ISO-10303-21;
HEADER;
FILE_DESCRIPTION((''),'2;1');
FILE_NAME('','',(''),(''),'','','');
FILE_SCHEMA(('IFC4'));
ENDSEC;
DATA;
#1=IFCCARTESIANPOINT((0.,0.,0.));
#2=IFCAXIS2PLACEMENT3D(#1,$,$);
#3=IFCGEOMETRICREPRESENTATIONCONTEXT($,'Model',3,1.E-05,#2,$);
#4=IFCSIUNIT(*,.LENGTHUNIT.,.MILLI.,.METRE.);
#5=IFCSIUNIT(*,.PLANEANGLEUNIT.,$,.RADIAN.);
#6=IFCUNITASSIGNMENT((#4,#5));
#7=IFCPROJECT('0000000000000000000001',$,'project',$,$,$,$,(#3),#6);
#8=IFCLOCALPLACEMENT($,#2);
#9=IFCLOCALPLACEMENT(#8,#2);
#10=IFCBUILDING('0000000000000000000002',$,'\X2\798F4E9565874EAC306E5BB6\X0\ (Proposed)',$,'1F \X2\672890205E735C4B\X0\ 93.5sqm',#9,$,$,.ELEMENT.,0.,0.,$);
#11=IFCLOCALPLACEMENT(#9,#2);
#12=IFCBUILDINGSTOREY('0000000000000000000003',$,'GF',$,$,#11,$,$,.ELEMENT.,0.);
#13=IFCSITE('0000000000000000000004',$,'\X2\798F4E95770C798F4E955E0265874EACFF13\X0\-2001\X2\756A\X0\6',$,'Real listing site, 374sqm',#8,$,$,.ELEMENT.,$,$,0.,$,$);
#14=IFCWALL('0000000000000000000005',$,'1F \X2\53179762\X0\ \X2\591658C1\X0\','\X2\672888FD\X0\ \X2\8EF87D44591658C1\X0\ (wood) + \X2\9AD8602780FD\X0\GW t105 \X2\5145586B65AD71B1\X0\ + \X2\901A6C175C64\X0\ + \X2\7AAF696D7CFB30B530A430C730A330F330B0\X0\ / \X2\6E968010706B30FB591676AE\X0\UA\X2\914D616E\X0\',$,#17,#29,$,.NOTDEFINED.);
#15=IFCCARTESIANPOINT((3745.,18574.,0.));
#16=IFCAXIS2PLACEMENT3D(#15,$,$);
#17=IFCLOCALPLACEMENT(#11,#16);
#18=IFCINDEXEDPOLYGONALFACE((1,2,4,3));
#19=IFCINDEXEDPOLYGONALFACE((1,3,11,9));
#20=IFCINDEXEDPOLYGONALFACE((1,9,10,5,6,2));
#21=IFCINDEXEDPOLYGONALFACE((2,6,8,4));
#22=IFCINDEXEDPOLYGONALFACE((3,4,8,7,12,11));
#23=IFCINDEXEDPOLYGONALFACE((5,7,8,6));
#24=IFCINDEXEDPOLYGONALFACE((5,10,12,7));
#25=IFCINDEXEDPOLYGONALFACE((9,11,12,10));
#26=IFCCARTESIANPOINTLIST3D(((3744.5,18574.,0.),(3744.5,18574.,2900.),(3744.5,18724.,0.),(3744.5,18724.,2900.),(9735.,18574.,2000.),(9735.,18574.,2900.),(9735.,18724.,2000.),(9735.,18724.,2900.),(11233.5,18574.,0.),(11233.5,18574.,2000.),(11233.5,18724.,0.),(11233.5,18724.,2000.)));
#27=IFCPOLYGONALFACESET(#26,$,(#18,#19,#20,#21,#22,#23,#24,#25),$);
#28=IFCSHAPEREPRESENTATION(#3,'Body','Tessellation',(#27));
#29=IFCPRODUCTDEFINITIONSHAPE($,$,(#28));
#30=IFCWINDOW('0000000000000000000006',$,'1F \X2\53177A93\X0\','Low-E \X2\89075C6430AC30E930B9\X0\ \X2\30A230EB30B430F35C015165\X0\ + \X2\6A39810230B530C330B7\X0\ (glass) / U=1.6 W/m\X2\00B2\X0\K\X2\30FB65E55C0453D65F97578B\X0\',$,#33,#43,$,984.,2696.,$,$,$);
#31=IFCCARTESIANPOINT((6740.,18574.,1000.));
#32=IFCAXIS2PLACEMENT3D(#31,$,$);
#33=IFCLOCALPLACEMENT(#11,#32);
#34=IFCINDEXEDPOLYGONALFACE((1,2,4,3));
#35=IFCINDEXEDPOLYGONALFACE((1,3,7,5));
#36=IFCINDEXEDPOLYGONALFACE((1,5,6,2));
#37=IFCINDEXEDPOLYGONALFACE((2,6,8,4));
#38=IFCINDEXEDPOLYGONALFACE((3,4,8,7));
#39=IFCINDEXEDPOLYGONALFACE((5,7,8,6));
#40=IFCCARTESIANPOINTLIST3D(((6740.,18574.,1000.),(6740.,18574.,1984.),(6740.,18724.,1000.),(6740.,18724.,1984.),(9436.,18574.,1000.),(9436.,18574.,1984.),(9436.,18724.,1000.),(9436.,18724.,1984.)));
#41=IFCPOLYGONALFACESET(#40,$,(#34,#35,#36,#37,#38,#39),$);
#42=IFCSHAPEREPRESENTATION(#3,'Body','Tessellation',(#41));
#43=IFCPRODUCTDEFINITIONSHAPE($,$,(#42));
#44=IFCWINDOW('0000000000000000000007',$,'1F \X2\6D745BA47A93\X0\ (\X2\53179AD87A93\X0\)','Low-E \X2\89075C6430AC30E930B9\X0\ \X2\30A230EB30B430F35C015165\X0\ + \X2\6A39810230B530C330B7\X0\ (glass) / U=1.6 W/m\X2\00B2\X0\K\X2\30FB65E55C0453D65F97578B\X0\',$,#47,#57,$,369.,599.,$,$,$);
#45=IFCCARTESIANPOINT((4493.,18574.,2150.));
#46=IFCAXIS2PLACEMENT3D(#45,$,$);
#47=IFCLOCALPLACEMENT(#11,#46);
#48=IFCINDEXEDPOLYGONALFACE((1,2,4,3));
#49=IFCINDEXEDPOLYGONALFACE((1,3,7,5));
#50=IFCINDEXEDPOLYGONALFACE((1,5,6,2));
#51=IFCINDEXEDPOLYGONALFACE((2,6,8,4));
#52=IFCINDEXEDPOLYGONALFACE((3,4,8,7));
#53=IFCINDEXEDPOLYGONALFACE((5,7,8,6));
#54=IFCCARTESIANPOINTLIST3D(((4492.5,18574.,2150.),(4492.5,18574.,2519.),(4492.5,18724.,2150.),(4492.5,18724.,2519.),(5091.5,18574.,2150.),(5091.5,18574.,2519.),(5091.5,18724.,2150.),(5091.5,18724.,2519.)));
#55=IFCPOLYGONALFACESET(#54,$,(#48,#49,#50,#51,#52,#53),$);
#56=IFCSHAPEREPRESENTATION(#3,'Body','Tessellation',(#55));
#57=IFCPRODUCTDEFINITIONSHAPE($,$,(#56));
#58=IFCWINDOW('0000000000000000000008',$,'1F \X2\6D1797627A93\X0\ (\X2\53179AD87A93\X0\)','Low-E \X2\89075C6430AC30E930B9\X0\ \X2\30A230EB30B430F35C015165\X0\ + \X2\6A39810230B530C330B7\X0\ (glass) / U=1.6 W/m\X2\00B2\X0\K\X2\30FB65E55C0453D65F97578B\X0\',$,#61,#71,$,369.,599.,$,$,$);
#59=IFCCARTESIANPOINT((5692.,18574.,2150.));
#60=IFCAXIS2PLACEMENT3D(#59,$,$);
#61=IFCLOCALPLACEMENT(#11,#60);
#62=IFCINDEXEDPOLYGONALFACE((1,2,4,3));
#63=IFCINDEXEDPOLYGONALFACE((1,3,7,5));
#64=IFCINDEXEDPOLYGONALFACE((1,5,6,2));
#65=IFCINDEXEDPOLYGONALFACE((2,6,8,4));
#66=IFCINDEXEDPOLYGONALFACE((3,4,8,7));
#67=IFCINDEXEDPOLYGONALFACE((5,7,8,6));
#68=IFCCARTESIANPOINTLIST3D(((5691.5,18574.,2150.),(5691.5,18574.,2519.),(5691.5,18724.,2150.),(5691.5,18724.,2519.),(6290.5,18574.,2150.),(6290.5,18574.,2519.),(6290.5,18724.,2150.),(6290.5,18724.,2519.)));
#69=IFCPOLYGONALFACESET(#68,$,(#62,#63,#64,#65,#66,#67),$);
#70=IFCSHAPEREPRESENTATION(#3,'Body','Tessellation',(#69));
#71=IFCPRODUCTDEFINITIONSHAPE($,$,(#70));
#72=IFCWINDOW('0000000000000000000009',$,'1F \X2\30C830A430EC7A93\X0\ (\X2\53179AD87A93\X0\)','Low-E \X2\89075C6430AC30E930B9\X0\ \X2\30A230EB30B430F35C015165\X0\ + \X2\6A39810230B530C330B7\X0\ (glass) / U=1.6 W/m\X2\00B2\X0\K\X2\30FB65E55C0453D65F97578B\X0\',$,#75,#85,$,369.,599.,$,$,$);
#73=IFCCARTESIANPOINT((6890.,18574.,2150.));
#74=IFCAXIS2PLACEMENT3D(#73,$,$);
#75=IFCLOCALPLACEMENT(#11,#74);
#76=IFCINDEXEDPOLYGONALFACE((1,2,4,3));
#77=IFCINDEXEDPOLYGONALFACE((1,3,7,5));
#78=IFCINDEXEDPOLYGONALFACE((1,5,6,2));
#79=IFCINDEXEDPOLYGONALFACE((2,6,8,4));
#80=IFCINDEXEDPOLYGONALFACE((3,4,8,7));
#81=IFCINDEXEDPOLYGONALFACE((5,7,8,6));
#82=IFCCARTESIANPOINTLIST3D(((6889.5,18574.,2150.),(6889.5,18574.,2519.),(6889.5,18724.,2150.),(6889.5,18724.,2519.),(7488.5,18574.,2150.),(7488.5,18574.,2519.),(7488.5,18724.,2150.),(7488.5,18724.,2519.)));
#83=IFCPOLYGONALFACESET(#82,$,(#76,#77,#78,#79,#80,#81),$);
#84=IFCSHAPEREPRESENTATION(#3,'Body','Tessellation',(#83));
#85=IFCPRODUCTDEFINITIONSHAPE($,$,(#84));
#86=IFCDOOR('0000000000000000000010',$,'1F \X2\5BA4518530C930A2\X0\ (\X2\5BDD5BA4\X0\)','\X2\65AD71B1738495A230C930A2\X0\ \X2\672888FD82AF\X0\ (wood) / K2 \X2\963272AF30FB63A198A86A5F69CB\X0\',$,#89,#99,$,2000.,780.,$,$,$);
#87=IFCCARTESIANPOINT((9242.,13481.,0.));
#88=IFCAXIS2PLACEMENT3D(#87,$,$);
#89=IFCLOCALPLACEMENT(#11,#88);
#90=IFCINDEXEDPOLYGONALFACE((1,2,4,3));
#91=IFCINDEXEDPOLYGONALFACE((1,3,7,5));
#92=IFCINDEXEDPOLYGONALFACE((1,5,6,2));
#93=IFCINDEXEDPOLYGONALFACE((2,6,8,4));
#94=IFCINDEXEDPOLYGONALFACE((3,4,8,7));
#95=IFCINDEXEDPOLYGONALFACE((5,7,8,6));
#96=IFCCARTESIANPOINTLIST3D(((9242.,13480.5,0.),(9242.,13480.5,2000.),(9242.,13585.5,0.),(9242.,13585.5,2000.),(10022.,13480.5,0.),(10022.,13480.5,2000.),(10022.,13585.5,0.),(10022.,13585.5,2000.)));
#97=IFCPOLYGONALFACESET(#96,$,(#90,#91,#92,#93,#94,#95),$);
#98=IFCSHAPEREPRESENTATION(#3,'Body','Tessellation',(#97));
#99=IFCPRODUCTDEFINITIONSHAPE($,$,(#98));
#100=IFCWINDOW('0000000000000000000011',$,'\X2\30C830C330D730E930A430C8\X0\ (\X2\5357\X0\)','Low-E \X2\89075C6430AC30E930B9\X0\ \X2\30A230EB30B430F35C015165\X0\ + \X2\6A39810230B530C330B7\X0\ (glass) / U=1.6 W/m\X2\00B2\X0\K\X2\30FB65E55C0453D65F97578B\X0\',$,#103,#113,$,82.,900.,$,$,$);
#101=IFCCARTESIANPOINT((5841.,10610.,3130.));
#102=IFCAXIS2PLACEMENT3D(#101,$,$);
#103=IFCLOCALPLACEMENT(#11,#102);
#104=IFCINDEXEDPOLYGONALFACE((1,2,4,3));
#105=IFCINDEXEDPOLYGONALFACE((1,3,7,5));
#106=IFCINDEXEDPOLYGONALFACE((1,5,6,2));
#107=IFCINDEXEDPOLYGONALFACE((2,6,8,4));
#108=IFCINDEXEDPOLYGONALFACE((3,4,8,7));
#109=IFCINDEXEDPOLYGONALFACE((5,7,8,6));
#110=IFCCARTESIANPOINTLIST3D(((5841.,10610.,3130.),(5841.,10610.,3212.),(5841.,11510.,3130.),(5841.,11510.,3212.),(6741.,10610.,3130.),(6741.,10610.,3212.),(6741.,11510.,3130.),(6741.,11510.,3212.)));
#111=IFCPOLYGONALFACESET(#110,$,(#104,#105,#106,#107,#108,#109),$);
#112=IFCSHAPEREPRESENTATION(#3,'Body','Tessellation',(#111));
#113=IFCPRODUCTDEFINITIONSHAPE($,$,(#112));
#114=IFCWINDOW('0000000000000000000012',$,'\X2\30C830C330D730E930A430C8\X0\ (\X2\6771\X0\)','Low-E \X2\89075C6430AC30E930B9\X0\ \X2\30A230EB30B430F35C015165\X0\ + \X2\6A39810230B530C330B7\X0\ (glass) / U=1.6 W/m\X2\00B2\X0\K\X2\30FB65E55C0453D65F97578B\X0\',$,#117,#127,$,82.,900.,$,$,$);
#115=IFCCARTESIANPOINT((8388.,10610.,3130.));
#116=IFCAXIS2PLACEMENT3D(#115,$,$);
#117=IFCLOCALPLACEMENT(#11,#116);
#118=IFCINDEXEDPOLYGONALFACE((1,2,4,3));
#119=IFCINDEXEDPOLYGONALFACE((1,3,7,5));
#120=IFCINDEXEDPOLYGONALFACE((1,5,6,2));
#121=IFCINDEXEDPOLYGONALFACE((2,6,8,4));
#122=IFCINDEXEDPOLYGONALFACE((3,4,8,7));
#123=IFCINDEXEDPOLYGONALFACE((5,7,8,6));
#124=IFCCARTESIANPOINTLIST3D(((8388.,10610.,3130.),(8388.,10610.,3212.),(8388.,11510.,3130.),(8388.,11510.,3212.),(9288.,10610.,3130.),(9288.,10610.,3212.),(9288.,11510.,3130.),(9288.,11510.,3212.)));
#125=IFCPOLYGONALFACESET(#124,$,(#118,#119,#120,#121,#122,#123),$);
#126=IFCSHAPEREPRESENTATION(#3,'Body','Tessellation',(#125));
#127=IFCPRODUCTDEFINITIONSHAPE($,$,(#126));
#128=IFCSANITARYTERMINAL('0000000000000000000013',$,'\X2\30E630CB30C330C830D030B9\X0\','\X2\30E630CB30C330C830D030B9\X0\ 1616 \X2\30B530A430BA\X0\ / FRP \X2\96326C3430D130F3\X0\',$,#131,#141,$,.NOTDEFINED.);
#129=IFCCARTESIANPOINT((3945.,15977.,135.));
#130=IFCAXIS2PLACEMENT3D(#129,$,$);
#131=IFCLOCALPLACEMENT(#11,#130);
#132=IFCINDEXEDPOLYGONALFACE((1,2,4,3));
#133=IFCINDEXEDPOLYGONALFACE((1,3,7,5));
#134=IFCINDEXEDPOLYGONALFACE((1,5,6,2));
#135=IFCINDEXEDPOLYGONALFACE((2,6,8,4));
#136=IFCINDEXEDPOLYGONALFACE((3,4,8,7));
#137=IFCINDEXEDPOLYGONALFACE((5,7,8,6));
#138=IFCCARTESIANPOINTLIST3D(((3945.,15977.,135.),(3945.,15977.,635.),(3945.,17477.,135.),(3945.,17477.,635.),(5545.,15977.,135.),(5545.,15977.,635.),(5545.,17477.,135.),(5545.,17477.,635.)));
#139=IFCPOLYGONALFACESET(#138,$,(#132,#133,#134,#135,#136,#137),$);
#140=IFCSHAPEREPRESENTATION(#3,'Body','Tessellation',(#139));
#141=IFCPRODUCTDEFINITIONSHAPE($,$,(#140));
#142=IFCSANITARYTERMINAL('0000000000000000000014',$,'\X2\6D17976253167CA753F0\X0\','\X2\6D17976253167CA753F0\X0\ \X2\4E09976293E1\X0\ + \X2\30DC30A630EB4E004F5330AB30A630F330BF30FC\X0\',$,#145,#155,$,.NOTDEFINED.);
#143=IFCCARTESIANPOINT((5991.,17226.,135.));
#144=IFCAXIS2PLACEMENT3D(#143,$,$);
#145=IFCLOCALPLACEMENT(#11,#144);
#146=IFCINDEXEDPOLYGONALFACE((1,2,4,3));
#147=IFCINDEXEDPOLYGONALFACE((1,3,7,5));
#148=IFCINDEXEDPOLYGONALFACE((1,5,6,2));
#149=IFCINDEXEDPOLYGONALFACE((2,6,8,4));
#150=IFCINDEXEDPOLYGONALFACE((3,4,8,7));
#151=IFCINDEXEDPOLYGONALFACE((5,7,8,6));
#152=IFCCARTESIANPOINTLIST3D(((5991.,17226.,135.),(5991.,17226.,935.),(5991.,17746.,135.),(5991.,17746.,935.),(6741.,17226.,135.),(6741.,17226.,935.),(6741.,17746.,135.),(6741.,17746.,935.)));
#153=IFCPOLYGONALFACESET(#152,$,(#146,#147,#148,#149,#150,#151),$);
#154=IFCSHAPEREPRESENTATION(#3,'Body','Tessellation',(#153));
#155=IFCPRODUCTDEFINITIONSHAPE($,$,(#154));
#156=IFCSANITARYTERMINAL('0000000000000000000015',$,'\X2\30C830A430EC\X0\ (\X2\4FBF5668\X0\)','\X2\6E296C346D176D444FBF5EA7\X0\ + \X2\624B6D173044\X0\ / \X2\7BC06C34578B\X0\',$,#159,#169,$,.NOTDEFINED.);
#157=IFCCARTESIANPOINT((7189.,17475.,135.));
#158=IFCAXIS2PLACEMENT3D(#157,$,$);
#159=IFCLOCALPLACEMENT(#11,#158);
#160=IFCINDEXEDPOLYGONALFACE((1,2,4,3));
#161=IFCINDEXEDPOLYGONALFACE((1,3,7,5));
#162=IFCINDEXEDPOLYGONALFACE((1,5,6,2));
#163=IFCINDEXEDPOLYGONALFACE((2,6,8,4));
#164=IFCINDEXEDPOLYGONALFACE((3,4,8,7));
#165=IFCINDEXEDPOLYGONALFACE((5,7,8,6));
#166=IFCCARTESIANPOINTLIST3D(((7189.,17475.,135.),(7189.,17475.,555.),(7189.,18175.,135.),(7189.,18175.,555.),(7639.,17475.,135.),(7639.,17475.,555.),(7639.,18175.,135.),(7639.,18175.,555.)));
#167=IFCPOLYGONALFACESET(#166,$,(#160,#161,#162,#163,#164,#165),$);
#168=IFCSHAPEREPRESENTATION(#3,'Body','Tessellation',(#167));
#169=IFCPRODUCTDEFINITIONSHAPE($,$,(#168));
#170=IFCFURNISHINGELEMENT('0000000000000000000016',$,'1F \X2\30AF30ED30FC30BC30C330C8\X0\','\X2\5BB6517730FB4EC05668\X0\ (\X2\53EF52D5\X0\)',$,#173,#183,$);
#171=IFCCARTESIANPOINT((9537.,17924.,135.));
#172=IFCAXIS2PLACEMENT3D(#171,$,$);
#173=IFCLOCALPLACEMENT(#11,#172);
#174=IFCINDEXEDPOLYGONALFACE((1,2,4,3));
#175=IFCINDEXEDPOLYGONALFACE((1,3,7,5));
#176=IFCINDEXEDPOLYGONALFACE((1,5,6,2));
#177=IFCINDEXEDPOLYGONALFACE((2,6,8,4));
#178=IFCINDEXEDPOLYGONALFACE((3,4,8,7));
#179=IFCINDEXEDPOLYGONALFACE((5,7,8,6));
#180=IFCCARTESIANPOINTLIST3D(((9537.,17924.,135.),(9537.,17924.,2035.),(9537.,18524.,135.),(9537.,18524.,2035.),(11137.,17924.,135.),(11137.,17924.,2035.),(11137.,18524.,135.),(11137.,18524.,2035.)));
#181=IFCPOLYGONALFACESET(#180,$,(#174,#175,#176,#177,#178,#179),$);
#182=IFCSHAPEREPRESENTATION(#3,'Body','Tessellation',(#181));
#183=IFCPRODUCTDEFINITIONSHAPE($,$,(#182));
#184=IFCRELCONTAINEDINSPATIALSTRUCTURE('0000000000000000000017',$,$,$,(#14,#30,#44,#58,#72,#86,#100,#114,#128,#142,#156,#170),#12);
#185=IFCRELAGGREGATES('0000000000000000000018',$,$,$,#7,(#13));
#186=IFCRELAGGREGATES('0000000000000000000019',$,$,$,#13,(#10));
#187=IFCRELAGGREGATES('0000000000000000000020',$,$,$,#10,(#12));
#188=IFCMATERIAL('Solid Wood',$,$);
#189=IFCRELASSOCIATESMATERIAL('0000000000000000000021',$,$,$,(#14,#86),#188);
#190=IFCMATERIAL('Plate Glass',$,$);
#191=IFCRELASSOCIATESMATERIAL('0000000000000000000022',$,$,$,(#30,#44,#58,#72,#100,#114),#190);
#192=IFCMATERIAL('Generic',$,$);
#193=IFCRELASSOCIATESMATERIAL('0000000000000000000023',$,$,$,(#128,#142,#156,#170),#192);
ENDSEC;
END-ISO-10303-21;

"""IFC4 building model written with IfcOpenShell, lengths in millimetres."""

from ifc_helpers import new_model, si_unit, frame, frame_2d, origin, place, context, project, spatial, rectangle, extrude, material, element, fill, save


model = new_model("IFC4")

# Units and contexts
model_context = context("Model", 3, precision=1e-05, world=origin())
ifc_project = project(units=[si_unit("LENGTHUNIT", "METRE", prefix="MILLI"), si_unit("PLANEANGLEUNIT", "RADIAN")], contexts=[model_context])

# Site, building, storey
site_placement = place(None, origin())
site = spatial("IfcSite", under=ifc_project, at=site_placement, Name="福井県福井市文京３-2001番6", ObjectType="Real listing site, 374sqm", CompositionType="ELEMENT", RefElevation=0.0)
building_placement = place(site_placement, origin())
building = spatial("IfcBuilding", under=site, at=building_placement, Name="福井文京の家 (Proposed)", ObjectType="1F 木造平屋 93.5sqm", CompositionType="ELEMENT", ElevationOfRefHeight=0.0, ElevationOfTerrain=0.0)
storey_placement = place(building_placement, origin())
storey = spatial("IfcBuildingStorey", under=building, at=storey_placement, Name="GF", CompositionType="ELEMENT", Elevation=0.0)

# Shared definitions
ifc_material_1 = material(Name="Solid Wood")

# Wall, openings, windows
wall_1_placement = place(storey_placement, frame((3745.0, 18574.0, 0.0)))
wall_1 = element("IfcWall", 1, at=wall_1_placement, inside=storey, material=ifc_material_1, Name="1F 北面 外壁", Description="木製 軸組外壁 (wood) + 高性能GW t105 充填断熱 + 通気層 + 窯業系サイディング / 準耐火・外皮UA配慮", PredefinedType="NOTDEFINED", context=model_context, shape_type="SweptSolid", body=[
    extrude(rectangle(XDim=7489.0, YDim=150.0, at=frame_2d((3744.0, 75.0))), frame((3745.0, 18574.0, 0.0)), (0.0, 0.0, 1.0), 2900.0),
])
opening_1_placement = place(storey_placement, frame((6740.0, 18574.0, 1000.0)))
opening_1 = element("IfcOpeningElement", 2, at=opening_1_placement, cuts=wall_1, PredefinedType="NOTDEFINED", context=model_context, shape_type="SweptSolid", body=[
    extrude(rectangle(XDim=2696.0, YDim=150.0, at=frame_2d((1348.0, 75.0))), frame((6740.0, 18574.0, 1000.0)), (0.0, 0.0, 1.0), 984.0),
])
opening_2_placement = place(storey_placement, frame((4493.0, 18574.0, 2150.0)))
opening_2 = element("IfcOpeningElement", 3, at=opening_2_placement, cuts=wall_1, PredefinedType="NOTDEFINED", context=model_context, shape_type="SweptSolid", body=[
    extrude(rectangle(XDim=599.0, YDim=150.0, at=frame_2d((299.0, 75.0))), frame((4493.0, 18574.0, 2150.0)), (0.0, 0.0, 1.0), 369.0),
])
opening_3_placement = place(storey_placement, frame((5692.0, 18574.0, 2150.0)))
opening_3 = element("IfcOpeningElement", 4, at=opening_3_placement, cuts=wall_1, PredefinedType="NOTDEFINED", context=model_context, shape_type="SweptSolid", body=[
    extrude(rectangle(XDim=599.0, YDim=150.0, at=frame_2d((299.0, 75.0))), frame((5692.0, 18574.0, 2150.0)), (0.0, 0.0, 1.0), 369.0),
])
opening_4_placement = place(storey_placement, frame((6890.0, 18574.0, 2150.0)))
opening_4 = element("IfcOpeningElement", 5, at=opening_4_placement, cuts=wall_1, PredefinedType="NOTDEFINED", context=model_context, shape_type="SweptSolid", body=[
    extrude(rectangle(XDim=599.0, YDim=150.0, at=frame_2d((299.0, 75.0))), frame((6890.0, 18574.0, 2150.0)), (0.0, 0.0, 1.0), 369.0),
])
ifc_material_2 = material(Name="Plate Glass")
window_1_placement = place(storey_placement, frame((6740.0, 18574.0, 1000.0)))
window_1 = element("IfcWindow", 6, at=window_1_placement, inside=storey, material=ifc_material_2, Name="1F 北窓", Description="Low-E 複層ガラス アルゴン封入 + 樹脂サッシ (glass) / U=1.6 W/m²K・日射取得型", OverallHeight=984.0, OverallWidth=2696.0, context=model_context, shape_type="SweptSolid", body=[
    extrude(rectangle(XDim=2696.0, YDim=150.0, at=frame_2d((1348.0, 75.0))), frame((6740.0, 18574.0, 1000.0)), (0.0, 0.0, 1.0), 984.0),
])
fill(opening_1, window_1)
window_2_placement = place(storey_placement, frame((4493.0, 18574.0, 2150.0)))
window_2 = element("IfcWindow", 7, at=window_2_placement, inside=storey, material=ifc_material_2, Name="1F 浴室窓 (北高窓)", Description="Low-E 複層ガラス アルゴン封入 + 樹脂サッシ (glass) / U=1.6 W/m²K・日射取得型", OverallHeight=369.0, OverallWidth=599.0, context=model_context, shape_type="SweptSolid", body=[
    extrude(rectangle(XDim=599.0, YDim=150.0, at=frame_2d((299.0, 75.0))), frame((4493.0, 18574.0, 2150.0)), (0.0, 0.0, 1.0), 369.0),
])
fill(opening_2, window_2)
window_3_placement = place(storey_placement, frame((5692.0, 18574.0, 2150.0)))
window_3 = element("IfcWindow", 8, at=window_3_placement, inside=storey, material=ifc_material_2, Name="1F 洗面窓 (北高窓)", Description="Low-E 複層ガラス アルゴン封入 + 樹脂サッシ (glass) / U=1.6 W/m²K・日射取得型", OverallHeight=369.0, OverallWidth=599.0, context=model_context, shape_type="SweptSolid", body=[
    extrude(rectangle(XDim=599.0, YDim=150.0, at=frame_2d((299.0, 75.0))), frame((5692.0, 18574.0, 2150.0)), (0.0, 0.0, 1.0), 369.0),
])
fill(opening_3, window_3)
window_4_placement = place(storey_placement, frame((6890.0, 18574.0, 2150.0)))
window_4 = element("IfcWindow", 9, at=window_4_placement, inside=storey, material=ifc_material_2, Name="1F トイレ窓 (北高窓)", Description="Low-E 複層ガラス アルゴン封入 + 樹脂サッシ (glass) / U=1.6 W/m²K・日射取得型", OverallHeight=369.0, OverallWidth=599.0, context=model_context, shape_type="SweptSolid", body=[
    extrude(rectangle(XDim=599.0, YDim=150.0, at=frame_2d((299.0, 75.0))), frame((6890.0, 18574.0, 2150.0)), (0.0, 0.0, 1.0), 369.0),
])
fill(opening_4, window_4)

# Door
door_1_placement = place(storey_placement, frame((9242.0, 13481.0, 0.0)))
element("IfcDoor", 10, at=door_1_placement, inside=storey, material=ifc_material_1, Name="1F 室内ドア (寝室)", Description="断熱玄関ドア 木製芯 (wood) / K2 防犯・採風機構", OverallHeight=2000.0, OverallWidth=780.0, context=model_context, shape_type="SweptSolid", body=[
    extrude(rectangle(XDim=780.0, YDim=105.0, at=frame_2d((390.0, 52.0))), frame((9242.0, 13481.0, 0.0)), (0.0, 0.0, 1.0), 2000.0),
])

# Windows
window_5_placement = place(storey_placement, frame((5841.0, 10610.0, 3130.0)))
element("IfcWindow", 11, at=window_5_placement, inside=storey, material=ifc_material_2, Name="トップライト (南)", Description="Low-E 複層ガラス アルゴン封入 + 樹脂サッシ (glass) / U=1.6 W/m²K・日射取得型", OverallHeight=82.0, OverallWidth=900.0, context=model_context, shape_type="SweptSolid", body=[
    extrude(rectangle(XDim=900.0, YDim=900.0, at=frame_2d((450.0, 450.0))), frame((5841.0, 10610.0, 3130.0)), (0.0, 0.0, 1.0), 82.0),
])
window_6_placement = place(storey_placement, frame((8388.0, 10610.0, 3130.0)))
element("IfcWindow", 12, at=window_6_placement, inside=storey, material=ifc_material_2, Name="トップライト (東)", Description="Low-E 複層ガラス アルゴン封入 + 樹脂サッシ (glass) / U=1.6 W/m²K・日射取得型", OverallHeight=82.0, OverallWidth=900.0, context=model_context, shape_type="SweptSolid", body=[
    extrude(rectangle(XDim=900.0, YDim=900.0, at=frame_2d((450.0, 450.0))), frame((8388.0, 10610.0, 3130.0)), (0.0, 0.0, 1.0), 82.0),
])

# Sanitary terminals
ifc_material_3 = material(Name="Generic")
sanitary_terminal_1_placement = place(storey_placement, frame((3945.0, 15977.0, 135.0)))
element("IfcSanitaryTerminal", 13, at=sanitary_terminal_1_placement, inside=storey, material=ifc_material_3, Name="ユニットバス", Description="ユニットバス 1616 サイズ / FRP 防水パン", PredefinedType="NOTDEFINED", context=model_context, shape_type="SweptSolid", body=[
    extrude(rectangle(XDim=1600.0, YDim=1500.0, at=frame_2d((800.0, 750.0))), frame((3945.0, 15977.0, 135.0)), (0.0, 0.0, 1.0), 500.0),
])
sanitary_terminal_2_placement = place(storey_placement, frame((5991.0, 17226.0, 135.0)))
element("IfcSanitaryTerminal", 14, at=sanitary_terminal_2_placement, inside=storey, material=ifc_material_3, Name="洗面化粧台", Description="洗面化粧台 三面鏡 + ボウル一体カウンター", PredefinedType="NOTDEFINED", context=model_context, shape_type="SweptSolid", body=[
    extrude(rectangle(XDim=750.0, YDim=520.0, at=frame_2d((375.0, 260.0))), frame((5991.0, 17226.0, 135.0)), (0.0, 0.0, 1.0), 800.0),
])
sanitary_terminal_3_placement = place(storey_placement, frame((7189.0, 17475.0, 135.0)))
element("IfcSanitaryTerminal", 15, at=sanitary_terminal_3_placement, inside=storey, material=ifc_material_3, Name="トイレ (便器)", Description="温水洗浄便座 + 手洗い / 節水型", PredefinedType="NOTDEFINED", context=model_context, shape_type="SweptSolid", body=[
    extrude(rectangle(XDim=450.0, YDim=700.0, at=frame_2d((225.0, 350.0))), frame((7189.0, 17475.0, 135.0)), (0.0, 0.0, 1.0), 420.0),
])

# Furnishing element
furnishing_1_placement = place(storey_placement, frame((9537.0, 17924.0, 135.0)))
element("IfcFurnishingElement", 16, at=furnishing_1_placement, inside=storey, material=ifc_material_3, Name="1F クローゼット", Description="家具・什器 (可動)", context=model_context, shape_type="SweptSolid", body=[
    extrude(rectangle(XDim=1600.0, YDim=600.0, at=frame_2d((800.0, 300.0))), frame((9537.0, 17924.0, 135.0)), (0.0, 0.0, 1.0), 1900.0),
])

save(model, "model.ifc")
